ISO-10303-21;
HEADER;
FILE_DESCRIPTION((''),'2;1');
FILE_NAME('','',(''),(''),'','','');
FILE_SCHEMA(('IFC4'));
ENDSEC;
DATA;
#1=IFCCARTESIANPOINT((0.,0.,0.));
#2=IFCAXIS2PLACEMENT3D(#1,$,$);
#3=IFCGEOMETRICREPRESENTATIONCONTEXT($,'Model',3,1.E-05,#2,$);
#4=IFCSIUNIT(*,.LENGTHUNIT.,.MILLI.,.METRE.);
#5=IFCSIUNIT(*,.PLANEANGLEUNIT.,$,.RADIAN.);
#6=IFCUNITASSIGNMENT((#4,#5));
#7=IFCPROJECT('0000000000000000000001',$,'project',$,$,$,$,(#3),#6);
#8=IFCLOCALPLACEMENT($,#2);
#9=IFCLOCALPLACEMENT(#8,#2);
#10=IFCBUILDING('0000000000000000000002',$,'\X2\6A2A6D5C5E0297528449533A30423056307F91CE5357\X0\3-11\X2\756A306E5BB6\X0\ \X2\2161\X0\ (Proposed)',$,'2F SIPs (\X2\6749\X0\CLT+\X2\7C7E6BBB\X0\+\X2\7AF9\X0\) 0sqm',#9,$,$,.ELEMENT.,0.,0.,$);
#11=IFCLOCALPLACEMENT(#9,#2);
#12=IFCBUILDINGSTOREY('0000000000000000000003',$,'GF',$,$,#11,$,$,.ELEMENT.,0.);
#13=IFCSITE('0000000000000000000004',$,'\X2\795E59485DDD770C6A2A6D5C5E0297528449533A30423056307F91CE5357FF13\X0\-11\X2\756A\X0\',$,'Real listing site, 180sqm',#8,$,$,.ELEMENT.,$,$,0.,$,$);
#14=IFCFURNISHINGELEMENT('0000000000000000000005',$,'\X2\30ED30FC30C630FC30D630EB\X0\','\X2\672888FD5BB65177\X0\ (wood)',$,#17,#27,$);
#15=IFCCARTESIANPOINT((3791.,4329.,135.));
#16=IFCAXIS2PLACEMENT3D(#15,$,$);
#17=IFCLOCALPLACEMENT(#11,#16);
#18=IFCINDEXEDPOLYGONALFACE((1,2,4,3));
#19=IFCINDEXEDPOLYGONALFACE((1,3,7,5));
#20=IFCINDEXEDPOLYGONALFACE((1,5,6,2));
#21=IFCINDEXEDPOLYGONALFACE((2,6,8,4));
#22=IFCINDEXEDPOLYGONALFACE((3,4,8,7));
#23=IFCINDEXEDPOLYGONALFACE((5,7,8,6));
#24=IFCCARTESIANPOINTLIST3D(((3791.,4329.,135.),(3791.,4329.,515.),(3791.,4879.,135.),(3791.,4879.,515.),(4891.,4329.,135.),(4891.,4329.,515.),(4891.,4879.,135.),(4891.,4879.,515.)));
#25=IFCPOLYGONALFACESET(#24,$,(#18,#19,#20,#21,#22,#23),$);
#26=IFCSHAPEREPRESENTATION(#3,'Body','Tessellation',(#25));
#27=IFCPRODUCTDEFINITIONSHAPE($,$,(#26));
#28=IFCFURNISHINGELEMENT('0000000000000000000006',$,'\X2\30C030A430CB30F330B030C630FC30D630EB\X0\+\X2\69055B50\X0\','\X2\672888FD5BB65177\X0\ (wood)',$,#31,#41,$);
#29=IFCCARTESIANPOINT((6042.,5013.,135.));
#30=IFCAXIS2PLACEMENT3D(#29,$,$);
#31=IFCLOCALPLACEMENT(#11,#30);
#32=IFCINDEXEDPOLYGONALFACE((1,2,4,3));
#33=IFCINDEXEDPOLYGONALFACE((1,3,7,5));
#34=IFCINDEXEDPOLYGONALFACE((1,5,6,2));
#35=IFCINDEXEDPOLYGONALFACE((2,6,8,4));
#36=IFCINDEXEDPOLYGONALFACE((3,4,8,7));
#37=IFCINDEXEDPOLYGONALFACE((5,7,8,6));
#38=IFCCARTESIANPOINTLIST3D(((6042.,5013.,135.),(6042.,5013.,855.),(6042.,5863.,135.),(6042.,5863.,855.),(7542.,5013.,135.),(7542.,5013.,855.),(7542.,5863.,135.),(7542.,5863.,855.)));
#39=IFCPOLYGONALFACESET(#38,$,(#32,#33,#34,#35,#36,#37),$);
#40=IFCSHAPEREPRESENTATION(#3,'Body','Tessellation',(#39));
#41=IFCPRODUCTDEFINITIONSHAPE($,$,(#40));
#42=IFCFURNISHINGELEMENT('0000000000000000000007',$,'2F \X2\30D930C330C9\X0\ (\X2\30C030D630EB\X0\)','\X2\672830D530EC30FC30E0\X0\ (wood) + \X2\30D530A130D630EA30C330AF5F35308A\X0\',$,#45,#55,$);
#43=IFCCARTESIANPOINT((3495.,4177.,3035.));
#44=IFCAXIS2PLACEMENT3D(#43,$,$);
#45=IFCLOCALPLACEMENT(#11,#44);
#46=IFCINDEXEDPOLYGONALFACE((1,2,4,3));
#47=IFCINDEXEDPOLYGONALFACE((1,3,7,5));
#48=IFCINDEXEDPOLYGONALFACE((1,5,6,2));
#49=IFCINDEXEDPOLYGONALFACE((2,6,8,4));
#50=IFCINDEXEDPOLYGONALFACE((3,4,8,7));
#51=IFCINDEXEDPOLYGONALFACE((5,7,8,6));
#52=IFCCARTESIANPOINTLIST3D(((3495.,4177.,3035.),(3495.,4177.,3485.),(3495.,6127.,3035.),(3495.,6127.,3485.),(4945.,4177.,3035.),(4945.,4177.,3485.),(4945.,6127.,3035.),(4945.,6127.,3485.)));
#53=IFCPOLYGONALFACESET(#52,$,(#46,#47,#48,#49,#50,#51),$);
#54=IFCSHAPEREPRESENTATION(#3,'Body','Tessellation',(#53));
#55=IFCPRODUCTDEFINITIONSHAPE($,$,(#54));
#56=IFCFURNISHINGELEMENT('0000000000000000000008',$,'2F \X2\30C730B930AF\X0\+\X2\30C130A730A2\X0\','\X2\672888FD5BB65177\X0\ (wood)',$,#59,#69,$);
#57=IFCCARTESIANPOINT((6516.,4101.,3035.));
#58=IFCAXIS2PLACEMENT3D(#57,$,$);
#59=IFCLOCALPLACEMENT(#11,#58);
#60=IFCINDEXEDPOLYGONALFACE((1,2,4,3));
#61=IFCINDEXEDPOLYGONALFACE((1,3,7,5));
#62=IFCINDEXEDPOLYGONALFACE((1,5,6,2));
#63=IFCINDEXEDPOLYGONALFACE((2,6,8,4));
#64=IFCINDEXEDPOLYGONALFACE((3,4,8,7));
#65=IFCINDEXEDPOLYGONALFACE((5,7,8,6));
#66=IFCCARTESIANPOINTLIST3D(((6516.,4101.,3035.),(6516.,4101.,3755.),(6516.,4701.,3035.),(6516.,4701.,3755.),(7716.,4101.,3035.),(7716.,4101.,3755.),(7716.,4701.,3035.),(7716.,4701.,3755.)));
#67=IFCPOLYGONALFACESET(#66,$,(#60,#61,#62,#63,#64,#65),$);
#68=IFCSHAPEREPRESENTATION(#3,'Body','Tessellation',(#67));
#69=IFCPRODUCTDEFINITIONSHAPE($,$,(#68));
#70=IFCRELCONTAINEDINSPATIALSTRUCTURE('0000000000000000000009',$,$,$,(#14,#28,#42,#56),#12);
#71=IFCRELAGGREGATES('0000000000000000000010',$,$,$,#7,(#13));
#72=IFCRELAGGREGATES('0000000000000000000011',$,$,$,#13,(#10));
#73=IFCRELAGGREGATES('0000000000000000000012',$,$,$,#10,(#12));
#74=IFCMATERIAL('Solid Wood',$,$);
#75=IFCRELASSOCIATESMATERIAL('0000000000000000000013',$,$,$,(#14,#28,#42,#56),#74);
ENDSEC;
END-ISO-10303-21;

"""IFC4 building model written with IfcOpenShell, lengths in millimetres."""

from ifc_helpers import new_model, si_unit, frame, frame_2d, origin, place, context, project, spatial, rectangle, extrude, material, element, save


model = new_model("IFC4")

# Units and contexts
model_context = context("Model", 3, precision=1e-05, world=origin())
ifc_project = project(units=[si_unit("LENGTHUNIT", "METRE", prefix="MILLI"), si_unit("PLANEANGLEUNIT", "RADIAN")], contexts=[model_context])

# Site, building, storey
site_placement = place(None, origin())
site = spatial("IfcSite", under=ifc_project, at=site_placement, Name="神奈川県横浜市青葉区あざみ野南３-11番", ObjectType="Real listing site, 180sqm", CompositionType="ELEMENT", RefElevation=0.0)
building_placement = place(site_placement, origin())
building = spatial("IfcBuilding", under=site, at=building_placement, Name="横浜市青葉区あざみ野南3-11番の家 Ⅱ (Proposed)", ObjectType="2F SIPs (杉CLT+籾殻+竹) 0sqm", CompositionType="ELEMENT", ElevationOfRefHeight=0.0, ElevationOfTerrain=0.0)
storey_placement = place(building_placement, origin())
storey = spatial("IfcBuildingStorey", under=building, at=storey_placement, Name="GF", CompositionType="ELEMENT", Elevation=0.0)

# Shared definitions
ifc_material_1 = material(Name="Solid Wood")

# Furnishing elements
furnishing_1_placement = place(storey_placement, frame((3791.0, 4329.0, 135.0)))
element("IfcFurnishingElement", 1, at=furnishing_1_placement, inside=storey, material=ifc_material_1, Name="ローテーブル", Description="木製家具 (wood)", context=model_context, shape_type="SweptSolid", body=[
    extrude(rectangle(XDim=1100.0, YDim=550.0, at=frame_2d((550.0, 275.0))), frame((3791.0, 4329.0, 135.0)), (0.0, 0.0, 1.0), 380.0),
])
furnishing_2_placement = place(storey_placement, frame((6042.0, 5013.0, 135.0)))
element("IfcFurnishingElement", 2, at=furnishing_2_placement, inside=storey, material=ifc_material_1, Name="ダイニングテーブル+椅子", Description="木製家具 (wood)", context=model_context, shape_type="SweptSolid", body=[
    extrude(rectangle(XDim=1500.0, YDim=850.0, at=frame_2d((750.0, 425.0))), frame((6042.0, 5013.0, 135.0)), (0.0, 0.0, 1.0), 720.0),
])
furnishing_3_placement = place(storey_placement, frame((3495.0, 4177.0, 3035.0)))
element("IfcFurnishingElement", 3, at=furnishing_3_placement, inside=storey, material=ifc_material_1, Name="2F ベッド (ダブル)", Description="木フレーム (wood) + ファブリック張り", context=model_context, shape_type="SweptSolid", body=[
    extrude(rectangle(XDim=1450.0, YDim=1950.0, at=frame_2d((725.0, 975.0))), frame((3495.0, 4177.0, 3035.0)), (0.0, 0.0, 1.0), 450.0),
])
furnishing_4_placement = place(storey_placement, frame((6516.0, 4101.0, 3035.0)))
element("IfcFurnishingElement", 4, at=furnishing_4_placement, inside=storey, material=ifc_material_1, Name="2F デスク+チェア", Description="木製家具 (wood)", context=model_context, shape_type="SweptSolid", body=[
    extrude(rectangle(XDim=1200.0, YDim=600.0, at=frame_2d((600.0, 300.0))), frame((6516.0, 4101.0, 3035.0)), (0.0, 0.0, 1.0), 720.0),
])

save(model, "model.ifc")
